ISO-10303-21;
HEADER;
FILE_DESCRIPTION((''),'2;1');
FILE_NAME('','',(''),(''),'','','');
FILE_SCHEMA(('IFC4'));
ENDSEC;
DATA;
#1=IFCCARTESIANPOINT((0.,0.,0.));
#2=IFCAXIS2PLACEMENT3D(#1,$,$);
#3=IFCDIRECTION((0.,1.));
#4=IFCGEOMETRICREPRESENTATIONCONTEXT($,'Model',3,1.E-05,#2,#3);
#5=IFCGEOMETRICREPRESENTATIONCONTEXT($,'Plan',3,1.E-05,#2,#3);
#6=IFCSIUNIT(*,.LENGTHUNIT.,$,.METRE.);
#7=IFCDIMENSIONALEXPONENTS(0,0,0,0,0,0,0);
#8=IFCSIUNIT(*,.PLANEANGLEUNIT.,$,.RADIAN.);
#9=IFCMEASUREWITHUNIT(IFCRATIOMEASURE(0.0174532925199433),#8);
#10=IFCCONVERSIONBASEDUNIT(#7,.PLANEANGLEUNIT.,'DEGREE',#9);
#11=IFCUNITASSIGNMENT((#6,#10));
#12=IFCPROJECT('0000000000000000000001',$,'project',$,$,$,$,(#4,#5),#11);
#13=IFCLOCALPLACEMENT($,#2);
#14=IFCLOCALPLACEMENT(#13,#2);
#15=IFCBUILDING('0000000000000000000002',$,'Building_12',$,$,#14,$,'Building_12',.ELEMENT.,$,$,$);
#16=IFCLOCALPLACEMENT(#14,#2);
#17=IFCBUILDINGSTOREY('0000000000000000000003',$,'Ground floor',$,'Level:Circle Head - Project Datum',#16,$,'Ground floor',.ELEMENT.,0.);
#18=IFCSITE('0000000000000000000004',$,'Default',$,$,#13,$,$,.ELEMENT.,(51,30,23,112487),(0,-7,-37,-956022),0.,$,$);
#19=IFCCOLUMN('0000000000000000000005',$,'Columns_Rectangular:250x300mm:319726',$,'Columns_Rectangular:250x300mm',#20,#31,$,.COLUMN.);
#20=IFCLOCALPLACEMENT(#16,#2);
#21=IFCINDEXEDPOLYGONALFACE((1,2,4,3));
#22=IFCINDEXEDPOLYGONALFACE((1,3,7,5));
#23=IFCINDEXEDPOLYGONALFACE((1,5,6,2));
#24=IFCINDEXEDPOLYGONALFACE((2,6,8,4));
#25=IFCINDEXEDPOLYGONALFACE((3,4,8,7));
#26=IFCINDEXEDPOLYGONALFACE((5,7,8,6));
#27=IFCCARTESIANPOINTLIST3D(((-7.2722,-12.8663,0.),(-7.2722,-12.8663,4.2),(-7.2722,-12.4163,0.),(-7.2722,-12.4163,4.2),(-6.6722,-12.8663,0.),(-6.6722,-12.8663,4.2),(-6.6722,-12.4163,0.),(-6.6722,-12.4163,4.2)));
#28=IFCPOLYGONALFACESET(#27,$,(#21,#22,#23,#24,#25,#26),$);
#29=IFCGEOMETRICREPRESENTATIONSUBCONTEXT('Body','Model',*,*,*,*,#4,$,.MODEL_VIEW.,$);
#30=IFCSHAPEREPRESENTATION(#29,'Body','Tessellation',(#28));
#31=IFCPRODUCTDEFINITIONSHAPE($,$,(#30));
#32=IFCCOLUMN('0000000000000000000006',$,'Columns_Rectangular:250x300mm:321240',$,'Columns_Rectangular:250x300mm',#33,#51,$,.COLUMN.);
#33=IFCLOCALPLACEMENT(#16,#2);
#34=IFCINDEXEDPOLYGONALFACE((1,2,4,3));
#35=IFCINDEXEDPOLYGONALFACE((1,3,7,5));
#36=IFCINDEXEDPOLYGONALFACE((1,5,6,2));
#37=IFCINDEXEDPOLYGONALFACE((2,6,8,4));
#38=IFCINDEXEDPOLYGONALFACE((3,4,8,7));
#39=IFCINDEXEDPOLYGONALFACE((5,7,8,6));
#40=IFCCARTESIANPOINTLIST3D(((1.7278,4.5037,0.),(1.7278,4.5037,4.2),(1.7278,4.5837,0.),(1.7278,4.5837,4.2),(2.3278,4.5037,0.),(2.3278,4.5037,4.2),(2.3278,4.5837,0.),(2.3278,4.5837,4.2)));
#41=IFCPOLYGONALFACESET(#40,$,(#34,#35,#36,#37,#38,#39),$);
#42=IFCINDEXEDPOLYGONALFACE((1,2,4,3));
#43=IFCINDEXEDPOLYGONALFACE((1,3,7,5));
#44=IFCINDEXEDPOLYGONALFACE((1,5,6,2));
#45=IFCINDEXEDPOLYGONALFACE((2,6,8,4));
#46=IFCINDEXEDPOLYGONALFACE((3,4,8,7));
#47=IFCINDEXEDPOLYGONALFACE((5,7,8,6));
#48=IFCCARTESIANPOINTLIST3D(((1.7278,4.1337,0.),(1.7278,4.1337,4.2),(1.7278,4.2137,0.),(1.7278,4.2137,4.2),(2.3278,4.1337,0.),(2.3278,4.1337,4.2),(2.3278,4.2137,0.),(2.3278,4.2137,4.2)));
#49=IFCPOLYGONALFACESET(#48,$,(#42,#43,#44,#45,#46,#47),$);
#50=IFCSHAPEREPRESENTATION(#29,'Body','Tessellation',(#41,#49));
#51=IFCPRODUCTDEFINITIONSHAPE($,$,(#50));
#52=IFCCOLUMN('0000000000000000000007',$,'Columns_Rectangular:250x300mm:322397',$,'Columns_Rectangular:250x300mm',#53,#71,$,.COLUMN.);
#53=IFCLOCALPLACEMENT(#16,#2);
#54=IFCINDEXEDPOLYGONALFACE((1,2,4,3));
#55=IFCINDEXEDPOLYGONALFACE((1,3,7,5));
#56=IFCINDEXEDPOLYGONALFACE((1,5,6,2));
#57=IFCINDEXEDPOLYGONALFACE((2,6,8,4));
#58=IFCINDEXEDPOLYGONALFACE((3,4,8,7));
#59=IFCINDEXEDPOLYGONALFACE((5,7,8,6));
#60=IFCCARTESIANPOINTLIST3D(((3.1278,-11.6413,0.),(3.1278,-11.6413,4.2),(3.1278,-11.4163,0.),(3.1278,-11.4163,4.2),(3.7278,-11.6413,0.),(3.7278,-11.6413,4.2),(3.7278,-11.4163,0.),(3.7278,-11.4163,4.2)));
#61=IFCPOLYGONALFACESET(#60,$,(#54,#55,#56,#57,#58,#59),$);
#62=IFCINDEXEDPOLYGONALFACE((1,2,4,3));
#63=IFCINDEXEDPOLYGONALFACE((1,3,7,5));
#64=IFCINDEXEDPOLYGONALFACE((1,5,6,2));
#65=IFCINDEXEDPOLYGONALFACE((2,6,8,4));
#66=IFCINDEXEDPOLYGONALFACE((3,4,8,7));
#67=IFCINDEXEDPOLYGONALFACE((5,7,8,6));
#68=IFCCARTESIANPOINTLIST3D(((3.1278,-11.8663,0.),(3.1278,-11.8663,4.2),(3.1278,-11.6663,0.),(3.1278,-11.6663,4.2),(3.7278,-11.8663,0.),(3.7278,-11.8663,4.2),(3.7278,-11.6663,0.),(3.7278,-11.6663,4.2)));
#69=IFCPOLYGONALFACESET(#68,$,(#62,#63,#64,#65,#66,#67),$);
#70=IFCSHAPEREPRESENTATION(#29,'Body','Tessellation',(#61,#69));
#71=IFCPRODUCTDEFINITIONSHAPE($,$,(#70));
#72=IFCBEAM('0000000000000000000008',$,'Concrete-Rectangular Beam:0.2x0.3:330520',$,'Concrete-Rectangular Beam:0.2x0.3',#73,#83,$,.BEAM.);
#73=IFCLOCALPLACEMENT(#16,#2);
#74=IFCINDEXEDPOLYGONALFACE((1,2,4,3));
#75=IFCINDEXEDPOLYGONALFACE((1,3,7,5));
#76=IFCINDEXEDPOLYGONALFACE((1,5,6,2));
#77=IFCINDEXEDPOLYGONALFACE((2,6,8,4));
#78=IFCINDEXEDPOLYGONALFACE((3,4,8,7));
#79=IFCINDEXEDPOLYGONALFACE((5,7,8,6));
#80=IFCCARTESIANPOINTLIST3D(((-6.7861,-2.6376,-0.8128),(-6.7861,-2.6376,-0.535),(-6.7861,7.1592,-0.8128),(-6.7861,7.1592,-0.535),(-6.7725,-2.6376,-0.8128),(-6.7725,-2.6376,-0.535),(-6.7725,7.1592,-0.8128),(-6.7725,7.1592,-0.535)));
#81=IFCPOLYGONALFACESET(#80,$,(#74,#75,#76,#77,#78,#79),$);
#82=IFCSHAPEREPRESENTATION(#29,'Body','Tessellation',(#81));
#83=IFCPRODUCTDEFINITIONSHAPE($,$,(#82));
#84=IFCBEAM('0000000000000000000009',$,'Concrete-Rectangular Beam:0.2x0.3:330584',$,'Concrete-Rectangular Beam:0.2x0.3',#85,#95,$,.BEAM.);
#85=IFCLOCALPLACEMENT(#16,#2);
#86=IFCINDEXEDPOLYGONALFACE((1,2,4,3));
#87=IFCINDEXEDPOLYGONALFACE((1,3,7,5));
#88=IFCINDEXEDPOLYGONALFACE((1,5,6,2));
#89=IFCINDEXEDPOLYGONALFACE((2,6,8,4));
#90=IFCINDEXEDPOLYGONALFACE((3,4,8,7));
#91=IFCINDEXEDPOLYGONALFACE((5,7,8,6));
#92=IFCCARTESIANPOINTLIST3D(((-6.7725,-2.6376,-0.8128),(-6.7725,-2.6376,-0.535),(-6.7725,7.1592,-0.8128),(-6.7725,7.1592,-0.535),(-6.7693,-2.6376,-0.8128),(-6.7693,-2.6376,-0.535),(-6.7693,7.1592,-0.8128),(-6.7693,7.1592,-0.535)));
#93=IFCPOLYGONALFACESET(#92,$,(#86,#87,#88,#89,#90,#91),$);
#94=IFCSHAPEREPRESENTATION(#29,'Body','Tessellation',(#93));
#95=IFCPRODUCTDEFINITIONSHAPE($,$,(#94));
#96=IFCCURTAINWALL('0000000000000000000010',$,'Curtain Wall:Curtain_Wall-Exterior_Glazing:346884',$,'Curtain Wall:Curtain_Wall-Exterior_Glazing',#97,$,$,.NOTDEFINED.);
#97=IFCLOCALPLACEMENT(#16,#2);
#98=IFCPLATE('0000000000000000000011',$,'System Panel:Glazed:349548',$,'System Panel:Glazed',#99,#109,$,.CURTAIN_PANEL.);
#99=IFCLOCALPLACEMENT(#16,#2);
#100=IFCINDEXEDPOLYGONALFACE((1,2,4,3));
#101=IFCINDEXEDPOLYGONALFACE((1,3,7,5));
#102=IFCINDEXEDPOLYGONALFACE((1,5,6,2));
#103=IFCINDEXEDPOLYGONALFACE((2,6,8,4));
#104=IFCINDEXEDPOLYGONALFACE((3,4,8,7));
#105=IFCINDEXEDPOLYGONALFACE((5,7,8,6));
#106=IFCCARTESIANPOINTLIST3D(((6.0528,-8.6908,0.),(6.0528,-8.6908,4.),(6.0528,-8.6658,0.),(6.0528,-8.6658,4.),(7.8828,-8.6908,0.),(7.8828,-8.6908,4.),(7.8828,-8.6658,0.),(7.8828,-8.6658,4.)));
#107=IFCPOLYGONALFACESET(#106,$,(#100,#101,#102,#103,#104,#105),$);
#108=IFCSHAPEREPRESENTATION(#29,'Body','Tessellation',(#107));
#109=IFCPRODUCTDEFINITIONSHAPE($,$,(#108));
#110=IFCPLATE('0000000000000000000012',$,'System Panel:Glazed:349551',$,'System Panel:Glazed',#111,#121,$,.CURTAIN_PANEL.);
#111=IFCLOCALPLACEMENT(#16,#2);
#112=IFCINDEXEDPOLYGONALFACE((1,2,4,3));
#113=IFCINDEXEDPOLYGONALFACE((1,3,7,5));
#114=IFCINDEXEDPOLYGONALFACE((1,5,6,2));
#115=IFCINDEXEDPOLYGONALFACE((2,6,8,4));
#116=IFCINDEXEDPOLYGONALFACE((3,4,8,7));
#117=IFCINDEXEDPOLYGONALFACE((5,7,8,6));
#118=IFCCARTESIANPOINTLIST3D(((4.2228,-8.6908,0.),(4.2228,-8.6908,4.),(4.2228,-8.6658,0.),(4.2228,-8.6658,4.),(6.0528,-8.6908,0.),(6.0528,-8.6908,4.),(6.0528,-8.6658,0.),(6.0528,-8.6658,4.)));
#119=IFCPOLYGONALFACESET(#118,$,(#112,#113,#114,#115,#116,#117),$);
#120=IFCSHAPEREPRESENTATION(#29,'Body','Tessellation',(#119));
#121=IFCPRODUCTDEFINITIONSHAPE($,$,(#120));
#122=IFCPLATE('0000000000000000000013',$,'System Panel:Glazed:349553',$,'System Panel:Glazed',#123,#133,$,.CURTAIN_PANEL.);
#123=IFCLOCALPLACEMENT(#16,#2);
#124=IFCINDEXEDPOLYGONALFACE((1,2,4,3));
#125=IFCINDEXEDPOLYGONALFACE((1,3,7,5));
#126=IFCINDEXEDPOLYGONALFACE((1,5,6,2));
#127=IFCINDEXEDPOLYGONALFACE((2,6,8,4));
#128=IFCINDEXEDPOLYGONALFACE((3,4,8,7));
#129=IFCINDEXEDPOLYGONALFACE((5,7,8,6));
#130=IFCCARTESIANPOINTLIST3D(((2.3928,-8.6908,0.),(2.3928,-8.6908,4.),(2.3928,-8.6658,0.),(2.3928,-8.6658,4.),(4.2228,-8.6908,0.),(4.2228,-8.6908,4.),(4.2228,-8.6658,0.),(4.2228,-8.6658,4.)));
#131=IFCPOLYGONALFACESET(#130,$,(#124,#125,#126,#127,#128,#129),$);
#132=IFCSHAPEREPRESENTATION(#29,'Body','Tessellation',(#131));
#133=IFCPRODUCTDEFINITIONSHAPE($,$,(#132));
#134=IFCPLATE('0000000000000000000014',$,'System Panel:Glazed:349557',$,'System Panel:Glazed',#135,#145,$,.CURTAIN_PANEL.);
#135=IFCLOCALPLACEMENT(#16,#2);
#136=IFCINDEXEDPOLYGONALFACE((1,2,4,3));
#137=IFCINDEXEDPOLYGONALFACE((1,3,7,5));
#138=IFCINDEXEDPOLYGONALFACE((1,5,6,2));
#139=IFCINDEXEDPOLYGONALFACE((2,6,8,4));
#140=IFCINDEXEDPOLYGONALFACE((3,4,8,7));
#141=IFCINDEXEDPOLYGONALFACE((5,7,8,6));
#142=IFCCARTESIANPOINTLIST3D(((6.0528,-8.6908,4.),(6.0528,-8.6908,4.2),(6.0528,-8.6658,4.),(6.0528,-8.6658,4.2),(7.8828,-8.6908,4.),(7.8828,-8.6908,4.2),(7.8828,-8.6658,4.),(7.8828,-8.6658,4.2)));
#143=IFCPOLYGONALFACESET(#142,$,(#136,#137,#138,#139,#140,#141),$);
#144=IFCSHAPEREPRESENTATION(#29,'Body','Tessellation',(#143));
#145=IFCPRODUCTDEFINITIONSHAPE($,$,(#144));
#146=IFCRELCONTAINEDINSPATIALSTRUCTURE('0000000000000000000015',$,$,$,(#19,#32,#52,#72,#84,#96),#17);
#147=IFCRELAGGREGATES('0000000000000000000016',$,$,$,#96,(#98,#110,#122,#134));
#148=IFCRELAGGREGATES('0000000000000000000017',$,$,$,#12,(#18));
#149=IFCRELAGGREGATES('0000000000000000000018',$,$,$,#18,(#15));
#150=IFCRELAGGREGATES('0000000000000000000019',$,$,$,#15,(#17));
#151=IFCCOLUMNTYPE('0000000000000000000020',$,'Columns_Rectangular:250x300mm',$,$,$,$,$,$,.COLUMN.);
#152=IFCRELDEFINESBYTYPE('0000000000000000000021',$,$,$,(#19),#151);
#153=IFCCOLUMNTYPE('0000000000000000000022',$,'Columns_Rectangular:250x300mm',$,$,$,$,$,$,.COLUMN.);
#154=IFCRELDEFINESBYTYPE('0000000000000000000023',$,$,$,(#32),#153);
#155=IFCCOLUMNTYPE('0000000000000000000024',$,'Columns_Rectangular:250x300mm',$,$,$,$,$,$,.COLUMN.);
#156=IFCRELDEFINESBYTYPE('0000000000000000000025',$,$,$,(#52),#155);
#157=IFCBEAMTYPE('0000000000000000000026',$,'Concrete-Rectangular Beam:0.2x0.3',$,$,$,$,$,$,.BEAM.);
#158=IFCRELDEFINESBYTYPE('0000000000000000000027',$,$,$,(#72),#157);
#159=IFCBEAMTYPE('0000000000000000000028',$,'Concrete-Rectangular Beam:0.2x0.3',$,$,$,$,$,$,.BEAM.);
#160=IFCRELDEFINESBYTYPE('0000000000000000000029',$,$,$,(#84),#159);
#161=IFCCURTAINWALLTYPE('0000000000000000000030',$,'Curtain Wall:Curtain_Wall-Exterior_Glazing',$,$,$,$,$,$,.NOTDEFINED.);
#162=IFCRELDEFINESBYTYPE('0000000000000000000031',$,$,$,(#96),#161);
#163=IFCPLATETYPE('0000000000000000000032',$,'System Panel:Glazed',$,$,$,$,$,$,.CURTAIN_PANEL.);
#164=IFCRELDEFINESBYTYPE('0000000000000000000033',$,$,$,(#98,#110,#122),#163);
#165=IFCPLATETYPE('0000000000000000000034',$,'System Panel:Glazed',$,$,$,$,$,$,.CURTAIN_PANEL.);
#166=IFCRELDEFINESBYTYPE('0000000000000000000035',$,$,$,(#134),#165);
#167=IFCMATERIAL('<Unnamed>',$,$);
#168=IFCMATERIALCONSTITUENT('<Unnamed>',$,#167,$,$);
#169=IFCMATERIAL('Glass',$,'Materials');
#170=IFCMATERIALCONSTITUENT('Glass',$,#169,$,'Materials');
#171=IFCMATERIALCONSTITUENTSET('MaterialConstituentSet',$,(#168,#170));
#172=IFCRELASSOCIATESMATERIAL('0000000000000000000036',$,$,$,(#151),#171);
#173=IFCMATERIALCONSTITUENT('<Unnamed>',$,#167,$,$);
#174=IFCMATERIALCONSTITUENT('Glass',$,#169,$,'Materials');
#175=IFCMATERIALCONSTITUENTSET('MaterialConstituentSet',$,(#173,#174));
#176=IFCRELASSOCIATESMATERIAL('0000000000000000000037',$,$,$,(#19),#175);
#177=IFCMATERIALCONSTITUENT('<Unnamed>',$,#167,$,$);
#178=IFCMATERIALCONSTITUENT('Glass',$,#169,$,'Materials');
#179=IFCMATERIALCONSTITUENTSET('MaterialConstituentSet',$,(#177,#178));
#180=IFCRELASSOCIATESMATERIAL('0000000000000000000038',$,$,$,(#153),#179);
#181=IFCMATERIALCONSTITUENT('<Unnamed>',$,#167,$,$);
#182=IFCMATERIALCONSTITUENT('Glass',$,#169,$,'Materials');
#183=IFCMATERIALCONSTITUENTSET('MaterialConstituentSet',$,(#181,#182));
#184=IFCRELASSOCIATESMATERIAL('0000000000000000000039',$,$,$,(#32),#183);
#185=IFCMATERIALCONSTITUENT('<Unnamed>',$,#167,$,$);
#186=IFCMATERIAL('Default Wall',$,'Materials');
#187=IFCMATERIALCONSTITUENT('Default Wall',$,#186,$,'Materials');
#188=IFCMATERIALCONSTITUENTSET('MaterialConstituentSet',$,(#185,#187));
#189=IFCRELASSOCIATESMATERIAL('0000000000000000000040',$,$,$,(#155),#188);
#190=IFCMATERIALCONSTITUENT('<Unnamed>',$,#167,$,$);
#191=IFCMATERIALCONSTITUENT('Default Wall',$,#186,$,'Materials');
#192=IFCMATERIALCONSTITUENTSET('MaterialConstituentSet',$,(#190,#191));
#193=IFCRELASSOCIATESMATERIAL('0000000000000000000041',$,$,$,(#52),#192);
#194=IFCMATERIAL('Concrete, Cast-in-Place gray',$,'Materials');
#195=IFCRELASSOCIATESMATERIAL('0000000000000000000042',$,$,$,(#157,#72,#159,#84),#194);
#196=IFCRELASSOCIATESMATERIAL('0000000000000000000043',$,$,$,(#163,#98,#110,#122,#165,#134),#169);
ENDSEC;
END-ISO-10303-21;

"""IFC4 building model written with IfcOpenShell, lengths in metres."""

from ifc_helpers import new_model, entity, si_unit, converted_unit, direction, frame, origin, place, context, subcontext, project, spatial, indexed_curve, outline, extrude, source, transform, mapped, material, constituent, constituent_set, type_object, type_shapes, element, aggregate, save


model = new_model("IFC4")

# Units and contexts
model_context = context("Model", 3, precision=1e-05, world=origin(), true_north=direction((0.0, 1.0)))
plan_context = context("Plan", 3, precision=1e-05, world=origin(), true_north=direction((0.0, 1.0)))
body_context = subcontext(model_context, "Body", "Model", "MODEL_VIEW")
ifc_project = project(units=[si_unit("LENGTHUNIT", "METRE"), converted_unit("PLANEANGLEUNIT", "DEGREE", entity("IfcRatioMeasure", 0.0174532925199433), si_unit("PLANEANGLEUNIT", "RADIAN"), dimensions=[0, 0, 0, 0, 0, 0, 0])], contexts=[model_context, plan_context])

# Site, building, storey
site_placement = place(None, origin())
site = spatial("IfcSite", under=ifc_project, at=site_placement, Name="Default", CompositionType="ELEMENT", RefLatitude=(51, 30, 23, 112487), RefLongitude=(0, -7, -37, -956022), RefElevation=0.0)
building_placement = place(site_placement, origin())
building = spatial("IfcBuilding", under=site, at=building_placement, Name="Building_12", LongName="Building_12", CompositionType="ELEMENT")
storey_placement = place(building_placement, origin())
storey = spatial("IfcBuildingStorey", under=building, at=storey_placement, Name="Ground floor", ObjectType="Level:Circle Head - Project Datum", LongName="Ground floor", CompositionType="ELEMENT", Elevation=0.0)

# Columns
ifc_material_1 = material(Name="<Unnamed>")
ifc_material_2 = material(Name="Default Wall", Category="Materials")
ifc_constituent_1 = constituent(ifc_material_1, Name="<Unnamed>")
ifc_material_3 = material(Name="Glass", Category="Materials")
ifc_constituent_2 = constituent(ifc_material_3, Name="Glass", Category="Materials")
ifc_constituent_set_1 = constituent_set(constituents=[ifc_constituent_1, ifc_constituent_2], Name="MaterialConstituentSet")
ifc_constituent_3 = constituent(ifc_material_1, Name="<Unnamed>")
ifc_constituent_4 = constituent(ifc_material_3, Name="Glass", Category="Materials")
ifc_constituent_set_2 = constituent_set(constituents=[ifc_constituent_3, ifc_constituent_4], Name="MaterialConstituentSet")
column_type_1 = type_object("IfcColumnType", Name="Columns_Rectangular:250x300mm", PredefinedType="COLUMN", material=ifc_constituent_set_2)
shared_shape_1 = source(origin(), body_context, "Body", "SweptSolid", [
    extrude(outline(indexed_curve([(-0.225, -0.3), (0.225, -0.3), (0.225, 0.3), (-0.225, 0.3), (-0.225, -0.3)], self_intersect=False)), frame((-6.9722, -12.6413, 0.0), z_axis=(0.0, 0.0, 1.0), x_axis=(0.0, -1.0, 0.0)), (0.0, 0.0, 1.0), 4.2),
])
type_shapes(column_type_1, [shared_shape_1])
column_1_placement = place(storey_placement, origin())
element("IfcColumn", 1, at=column_1_placement, inside=storey, type_object=column_type_1, material=ifc_constituent_set_1, Name="Columns_Rectangular:250x300mm:319726", ObjectType="Columns_Rectangular:250x300mm", PredefinedType="COLUMN", context=body_context, shape_type="MappedRepresentation", body=[
    mapped(shared_shape_1, transform((0.0, 0.0, 0.0), scale=1.0)),
])
ifc_constituent_5 = constituent(ifc_material_1, Name="<Unnamed>")
ifc_constituent_6 = constituent(ifc_material_3, Name="Glass", Category="Materials")
ifc_constituent_set_3 = constituent_set(constituents=[ifc_constituent_5, ifc_constituent_6], Name="MaterialConstituentSet")
ifc_constituent_7 = constituent(ifc_material_1, Name="<Unnamed>")
ifc_constituent_8 = constituent(ifc_material_3, Name="Glass", Category="Materials")
ifc_constituent_set_4 = constituent_set(constituents=[ifc_constituent_7, ifc_constituent_8], Name="MaterialConstituentSet")
column_type_2 = type_object("IfcColumnType", Name="Columns_Rectangular:250x300mm", PredefinedType="COLUMN", material=ifc_constituent_set_4)
shared_shape_2 = source(origin(), body_context, "Body", "SweptSolid", [
    extrude(outline(indexed_curve([(-0.04, -0.3), (0.04, -0.3), (0.04, 0.3), (-0.04, 0.3), (-0.04, -0.3)], self_intersect=False)), frame((2.0278, 4.5437, 0.0), z_axis=(0.0, 0.0, 1.0), x_axis=(0.0, -1.0, 0.0)), (0.0, 0.0, 1.0), 4.2),
    extrude(outline(indexed_curve([(-0.04, -0.3), (0.04, -0.3), (0.04, 0.3), (-0.04, 0.3), (-0.04, -0.3)], self_intersect=False)), frame((2.0278, 4.1737, 0.0), z_axis=(0.0, 0.0, 1.0), x_axis=(0.0, -1.0, 0.0)), (0.0, 0.0, 1.0), 4.2),
])
type_shapes(column_type_2, [shared_shape_2])
column_2_placement = place(storey_placement, origin())
element("IfcColumn", 2, at=column_2_placement, inside=storey, type_object=column_type_2, material=ifc_constituent_set_3, Name="Columns_Rectangular:250x300mm:321240", ObjectType="Columns_Rectangular:250x300mm", PredefinedType="COLUMN", context=body_context, shape_type="MappedRepresentation", body=[
    mapped(shared_shape_2, transform((0.0, 0.0, 0.0), scale=1.0)),
])
ifc_constituent_9 = constituent(ifc_material_1, Name="<Unnamed>")
ifc_constituent_10 = constituent(ifc_material_2, Name="Default Wall", Category="Materials")
ifc_constituent_set_5 = constituent_set(constituents=[ifc_constituent_9, ifc_constituent_10], Name="MaterialConstituentSet")
ifc_constituent_11 = constituent(ifc_material_1, Name="<Unnamed>")
ifc_constituent_12 = constituent(ifc_material_2, Name="Default Wall", Category="Materials")
ifc_constituent_set_6 = constituent_set(constituents=[ifc_constituent_11, ifc_constituent_12], Name="MaterialConstituentSet")
column_type_3 = type_object("IfcColumnType", Name="Columns_Rectangular:250x300mm", PredefinedType="COLUMN", material=ifc_constituent_set_6)
shared_shape_3 = source(origin(), body_context, "Body", "SweptSolid", [
    extrude(outline(indexed_curve([(-0.1125, -0.3), (0.1125, -0.3), (0.1125, 0.3), (-0.1125, 0.3), (-0.1125, -0.3)], self_intersect=False)), frame((3.4278, -11.5288, 0.0), z_axis=(0.0, 0.0, 1.0), x_axis=(0.0, -1.0, 0.0)), (0.0, 0.0, 1.0), 4.2),
    extrude(outline(indexed_curve([(-0.1, -0.3), (0.1, -0.3), (0.1, 0.3), (-0.1, 0.3), (-0.1, -0.3)], self_intersect=False)), frame((3.4278, -11.7663, 0.0), z_axis=(0.0, 0.0, 1.0), x_axis=(0.0, -1.0, 0.0)), (0.0, 0.0, 1.0), 4.2),
])
type_shapes(column_type_3, [shared_shape_3])
column_3_placement = place(storey_placement, origin())
element("IfcColumn", 3, at=column_3_placement, inside=storey, type_object=column_type_3, material=ifc_constituent_set_5, Name="Columns_Rectangular:250x300mm:322397", ObjectType="Columns_Rectangular:250x300mm", PredefinedType="COLUMN", context=body_context, shape_type="MappedRepresentation", body=[
    mapped(shared_shape_3, transform((0.0, 0.0, 0.0), scale=1.0)),
])

# Beams
ifc_material_4 = material(Name="Concrete, Cast-in-Place gray", Category="Materials")
beam_type_1 = type_object("IfcBeamType", Name="Concrete-Rectangular Beam:0.2x0.3", PredefinedType="BEAM", material=ifc_material_4)
shared_shape_4 = source(origin(), body_context, "Body", "SweptSolid", [
    extrude(outline(indexed_curve([(-0.0068, -0.1389), (0.0068, -0.1389), (0.0068, 0.1389), (-0.0068, 0.1389), (-0.0068, -0.1389)], self_intersect=False)), frame((-6.7793, 7.1592, -0.6739), z_axis=(0.0, -1.0, 0.0), x_axis=(-1.0, 0.0, 0.0)), (0.0, 0.0, 1.0), 9.7968),
])
type_shapes(beam_type_1, [shared_shape_4])
beam_1_placement = place(storey_placement, origin())
element("IfcBeam", 4, at=beam_1_placement, inside=storey, type_object=beam_type_1, material=ifc_material_4, Name="Concrete-Rectangular Beam:0.2x0.3:330520", ObjectType="Concrete-Rectangular Beam:0.2x0.3", PredefinedType="BEAM", context=body_context, shape_type="MappedRepresentation", body=[
    mapped(shared_shape_4, transform((0.0, 0.0, 0.0), scale=1.0)),
])
beam_type_2 = type_object("IfcBeamType", Name="Concrete-Rectangular Beam:0.2x0.3", PredefinedType="BEAM", material=ifc_material_4)
shared_shape_5 = source(origin(), body_context, "Body", "SweptSolid", [
    extrude(outline(indexed_curve([(-0.0016, -0.1389), (0.0016, -0.1389), (0.0016, 0.1389), (-0.0016, 0.1389), (-0.0016, -0.1389)], self_intersect=False)), frame((-6.7709, 7.1592, -0.6739), z_axis=(0.0, -1.0, 0.0), x_axis=(-1.0, 0.0, 0.0)), (0.0, 0.0, 1.0), 9.7968),
])
type_shapes(beam_type_2, [shared_shape_5])
beam_2_placement = place(storey_placement, origin())
element("IfcBeam", 5, at=beam_2_placement, inside=storey, type_object=beam_type_2, material=ifc_material_4, Name="Concrete-Rectangular Beam:0.2x0.3:330584", ObjectType="Concrete-Rectangular Beam:0.2x0.3", PredefinedType="BEAM", context=body_context, shape_type="MappedRepresentation", body=[
    mapped(shared_shape_5, transform((0.0, 0.0, 0.0), scale=1.0)),
])

# Curtain wall, plates
curtain_wall_type = type_object("IfcCurtainWallType", Name="Curtain Wall:Curtain_Wall-Exterior_Glazing", PredefinedType="NOTDEFINED")
curtain_wall_1_placement = place(storey_placement, origin())
curtain_wall_1 = element("IfcCurtainWall", 6, at=curtain_wall_1_placement, inside=storey, type_object=curtain_wall_type, Name="Curtain Wall:Curtain_Wall-Exterior_Glazing:346884", ObjectType="Curtain Wall:Curtain_Wall-Exterior_Glazing", PredefinedType="NOTDEFINED")
plate_type_1 = type_object("IfcPlateType", Name="System Panel:Glazed", PredefinedType="CURTAIN_PANEL", material=ifc_material_3)
shared_shape_6 = source(origin(), body_context, "Body", "SweptSolid", [
    extrude(outline(indexed_curve([(-0.0125, -0.915), (0.0125, -0.915), (0.0125, 0.915), (-0.0125, 0.915), (-0.0125, -0.915)], self_intersect=False)), frame((0.0, 0.037, 0.0), z_axis=(0.0, 0.0, 1.0), x_axis=(0.0, 1.0, 0.0)), (0.0, 0.0, 1.0), 4.0),
])
type_shapes(plate_type_1, [shared_shape_6])
plate_1_placement = place(curtain_wall_1_placement, frame((6.9678, -8.6413, 0.0), z_axis=(0.0, 0.0, 1.0), x_axis=(-1.0, 0.0, 0.0)))
plate_1 = element("IfcPlate", 7, at=plate_1_placement, type_object=plate_type_1, material=ifc_material_3, Name="System Panel:Glazed:349548", ObjectType="System Panel:Glazed", PredefinedType="CURTAIN_PANEL", context=body_context, shape_type="MappedRepresentation", body=[
    mapped(shared_shape_6, transform((0.0, 0.0, 0.0), scale=1.0)),
])
plate_2_placement = place(curtain_wall_1_placement, frame((5.1378, -8.6413, 0.0), z_axis=(0.0, 0.0, 1.0), x_axis=(-1.0, 0.0, 0.0)))
plate_2 = element("IfcPlate", 8, at=plate_2_placement, type_object=plate_type_1, material=ifc_material_3, Name="System Panel:Glazed:349551", ObjectType="System Panel:Glazed", PredefinedType="CURTAIN_PANEL", context=body_context, shape_type="MappedRepresentation", body=[
    mapped(shared_shape_6, transform((0.0, 0.0, 0.0), scale=1.0)),
])
plate_3_placement = place(curtain_wall_1_placement, frame((3.3078, -8.6413, 0.0), z_axis=(0.0, 0.0, 1.0), x_axis=(-1.0, 0.0, 0.0)))
plate_3 = element("IfcPlate", 9, at=plate_3_placement, type_object=plate_type_1, material=ifc_material_3, Name="System Panel:Glazed:349553", ObjectType="System Panel:Glazed", PredefinedType="CURTAIN_PANEL", context=body_context, shape_type="MappedRepresentation", body=[
    mapped(shared_shape_6, transform((0.0, 0.0, 0.0), scale=1.0)),
])
plate_type_2 = type_object("IfcPlateType", Name="System Panel:Glazed", PredefinedType="CURTAIN_PANEL", material=ifc_material_3)
shared_shape_7 = source(origin(), body_context, "Body", "SweptSolid", [
    extrude(outline(indexed_curve([(-0.0125, -0.915), (0.0125, -0.915), (0.0125, 0.915), (-0.0125, 0.915), (-0.0125, -0.915)], self_intersect=False)), frame((0.0, 0.037, 0.0), z_axis=(0.0, 0.0, 1.0), x_axis=(0.0, 1.0, 0.0)), (0.0, 0.0, 1.0), 0.2),
])
type_shapes(plate_type_2, [shared_shape_7])
plate_4_placement = place(curtain_wall_1_placement, frame((6.9678, -8.6413, 4.0), z_axis=(0.0, 0.0, 1.0), x_axis=(-1.0, 0.0, 0.0)))
plate_4 = element("IfcPlate", 10, at=plate_4_placement, type_object=plate_type_2, material=ifc_material_3, Name="System Panel:Glazed:349557", ObjectType="System Panel:Glazed", PredefinedType="CURTAIN_PANEL", context=body_context, shape_type="MappedRepresentation", body=[
    mapped(shared_shape_7, transform((0.0, 0.0, 0.0), scale=1.0)),
])

aggregate(curtain_wall_1, [plate_1, plate_2, plate_3, plate_4])

save(model, "model.ifc")
